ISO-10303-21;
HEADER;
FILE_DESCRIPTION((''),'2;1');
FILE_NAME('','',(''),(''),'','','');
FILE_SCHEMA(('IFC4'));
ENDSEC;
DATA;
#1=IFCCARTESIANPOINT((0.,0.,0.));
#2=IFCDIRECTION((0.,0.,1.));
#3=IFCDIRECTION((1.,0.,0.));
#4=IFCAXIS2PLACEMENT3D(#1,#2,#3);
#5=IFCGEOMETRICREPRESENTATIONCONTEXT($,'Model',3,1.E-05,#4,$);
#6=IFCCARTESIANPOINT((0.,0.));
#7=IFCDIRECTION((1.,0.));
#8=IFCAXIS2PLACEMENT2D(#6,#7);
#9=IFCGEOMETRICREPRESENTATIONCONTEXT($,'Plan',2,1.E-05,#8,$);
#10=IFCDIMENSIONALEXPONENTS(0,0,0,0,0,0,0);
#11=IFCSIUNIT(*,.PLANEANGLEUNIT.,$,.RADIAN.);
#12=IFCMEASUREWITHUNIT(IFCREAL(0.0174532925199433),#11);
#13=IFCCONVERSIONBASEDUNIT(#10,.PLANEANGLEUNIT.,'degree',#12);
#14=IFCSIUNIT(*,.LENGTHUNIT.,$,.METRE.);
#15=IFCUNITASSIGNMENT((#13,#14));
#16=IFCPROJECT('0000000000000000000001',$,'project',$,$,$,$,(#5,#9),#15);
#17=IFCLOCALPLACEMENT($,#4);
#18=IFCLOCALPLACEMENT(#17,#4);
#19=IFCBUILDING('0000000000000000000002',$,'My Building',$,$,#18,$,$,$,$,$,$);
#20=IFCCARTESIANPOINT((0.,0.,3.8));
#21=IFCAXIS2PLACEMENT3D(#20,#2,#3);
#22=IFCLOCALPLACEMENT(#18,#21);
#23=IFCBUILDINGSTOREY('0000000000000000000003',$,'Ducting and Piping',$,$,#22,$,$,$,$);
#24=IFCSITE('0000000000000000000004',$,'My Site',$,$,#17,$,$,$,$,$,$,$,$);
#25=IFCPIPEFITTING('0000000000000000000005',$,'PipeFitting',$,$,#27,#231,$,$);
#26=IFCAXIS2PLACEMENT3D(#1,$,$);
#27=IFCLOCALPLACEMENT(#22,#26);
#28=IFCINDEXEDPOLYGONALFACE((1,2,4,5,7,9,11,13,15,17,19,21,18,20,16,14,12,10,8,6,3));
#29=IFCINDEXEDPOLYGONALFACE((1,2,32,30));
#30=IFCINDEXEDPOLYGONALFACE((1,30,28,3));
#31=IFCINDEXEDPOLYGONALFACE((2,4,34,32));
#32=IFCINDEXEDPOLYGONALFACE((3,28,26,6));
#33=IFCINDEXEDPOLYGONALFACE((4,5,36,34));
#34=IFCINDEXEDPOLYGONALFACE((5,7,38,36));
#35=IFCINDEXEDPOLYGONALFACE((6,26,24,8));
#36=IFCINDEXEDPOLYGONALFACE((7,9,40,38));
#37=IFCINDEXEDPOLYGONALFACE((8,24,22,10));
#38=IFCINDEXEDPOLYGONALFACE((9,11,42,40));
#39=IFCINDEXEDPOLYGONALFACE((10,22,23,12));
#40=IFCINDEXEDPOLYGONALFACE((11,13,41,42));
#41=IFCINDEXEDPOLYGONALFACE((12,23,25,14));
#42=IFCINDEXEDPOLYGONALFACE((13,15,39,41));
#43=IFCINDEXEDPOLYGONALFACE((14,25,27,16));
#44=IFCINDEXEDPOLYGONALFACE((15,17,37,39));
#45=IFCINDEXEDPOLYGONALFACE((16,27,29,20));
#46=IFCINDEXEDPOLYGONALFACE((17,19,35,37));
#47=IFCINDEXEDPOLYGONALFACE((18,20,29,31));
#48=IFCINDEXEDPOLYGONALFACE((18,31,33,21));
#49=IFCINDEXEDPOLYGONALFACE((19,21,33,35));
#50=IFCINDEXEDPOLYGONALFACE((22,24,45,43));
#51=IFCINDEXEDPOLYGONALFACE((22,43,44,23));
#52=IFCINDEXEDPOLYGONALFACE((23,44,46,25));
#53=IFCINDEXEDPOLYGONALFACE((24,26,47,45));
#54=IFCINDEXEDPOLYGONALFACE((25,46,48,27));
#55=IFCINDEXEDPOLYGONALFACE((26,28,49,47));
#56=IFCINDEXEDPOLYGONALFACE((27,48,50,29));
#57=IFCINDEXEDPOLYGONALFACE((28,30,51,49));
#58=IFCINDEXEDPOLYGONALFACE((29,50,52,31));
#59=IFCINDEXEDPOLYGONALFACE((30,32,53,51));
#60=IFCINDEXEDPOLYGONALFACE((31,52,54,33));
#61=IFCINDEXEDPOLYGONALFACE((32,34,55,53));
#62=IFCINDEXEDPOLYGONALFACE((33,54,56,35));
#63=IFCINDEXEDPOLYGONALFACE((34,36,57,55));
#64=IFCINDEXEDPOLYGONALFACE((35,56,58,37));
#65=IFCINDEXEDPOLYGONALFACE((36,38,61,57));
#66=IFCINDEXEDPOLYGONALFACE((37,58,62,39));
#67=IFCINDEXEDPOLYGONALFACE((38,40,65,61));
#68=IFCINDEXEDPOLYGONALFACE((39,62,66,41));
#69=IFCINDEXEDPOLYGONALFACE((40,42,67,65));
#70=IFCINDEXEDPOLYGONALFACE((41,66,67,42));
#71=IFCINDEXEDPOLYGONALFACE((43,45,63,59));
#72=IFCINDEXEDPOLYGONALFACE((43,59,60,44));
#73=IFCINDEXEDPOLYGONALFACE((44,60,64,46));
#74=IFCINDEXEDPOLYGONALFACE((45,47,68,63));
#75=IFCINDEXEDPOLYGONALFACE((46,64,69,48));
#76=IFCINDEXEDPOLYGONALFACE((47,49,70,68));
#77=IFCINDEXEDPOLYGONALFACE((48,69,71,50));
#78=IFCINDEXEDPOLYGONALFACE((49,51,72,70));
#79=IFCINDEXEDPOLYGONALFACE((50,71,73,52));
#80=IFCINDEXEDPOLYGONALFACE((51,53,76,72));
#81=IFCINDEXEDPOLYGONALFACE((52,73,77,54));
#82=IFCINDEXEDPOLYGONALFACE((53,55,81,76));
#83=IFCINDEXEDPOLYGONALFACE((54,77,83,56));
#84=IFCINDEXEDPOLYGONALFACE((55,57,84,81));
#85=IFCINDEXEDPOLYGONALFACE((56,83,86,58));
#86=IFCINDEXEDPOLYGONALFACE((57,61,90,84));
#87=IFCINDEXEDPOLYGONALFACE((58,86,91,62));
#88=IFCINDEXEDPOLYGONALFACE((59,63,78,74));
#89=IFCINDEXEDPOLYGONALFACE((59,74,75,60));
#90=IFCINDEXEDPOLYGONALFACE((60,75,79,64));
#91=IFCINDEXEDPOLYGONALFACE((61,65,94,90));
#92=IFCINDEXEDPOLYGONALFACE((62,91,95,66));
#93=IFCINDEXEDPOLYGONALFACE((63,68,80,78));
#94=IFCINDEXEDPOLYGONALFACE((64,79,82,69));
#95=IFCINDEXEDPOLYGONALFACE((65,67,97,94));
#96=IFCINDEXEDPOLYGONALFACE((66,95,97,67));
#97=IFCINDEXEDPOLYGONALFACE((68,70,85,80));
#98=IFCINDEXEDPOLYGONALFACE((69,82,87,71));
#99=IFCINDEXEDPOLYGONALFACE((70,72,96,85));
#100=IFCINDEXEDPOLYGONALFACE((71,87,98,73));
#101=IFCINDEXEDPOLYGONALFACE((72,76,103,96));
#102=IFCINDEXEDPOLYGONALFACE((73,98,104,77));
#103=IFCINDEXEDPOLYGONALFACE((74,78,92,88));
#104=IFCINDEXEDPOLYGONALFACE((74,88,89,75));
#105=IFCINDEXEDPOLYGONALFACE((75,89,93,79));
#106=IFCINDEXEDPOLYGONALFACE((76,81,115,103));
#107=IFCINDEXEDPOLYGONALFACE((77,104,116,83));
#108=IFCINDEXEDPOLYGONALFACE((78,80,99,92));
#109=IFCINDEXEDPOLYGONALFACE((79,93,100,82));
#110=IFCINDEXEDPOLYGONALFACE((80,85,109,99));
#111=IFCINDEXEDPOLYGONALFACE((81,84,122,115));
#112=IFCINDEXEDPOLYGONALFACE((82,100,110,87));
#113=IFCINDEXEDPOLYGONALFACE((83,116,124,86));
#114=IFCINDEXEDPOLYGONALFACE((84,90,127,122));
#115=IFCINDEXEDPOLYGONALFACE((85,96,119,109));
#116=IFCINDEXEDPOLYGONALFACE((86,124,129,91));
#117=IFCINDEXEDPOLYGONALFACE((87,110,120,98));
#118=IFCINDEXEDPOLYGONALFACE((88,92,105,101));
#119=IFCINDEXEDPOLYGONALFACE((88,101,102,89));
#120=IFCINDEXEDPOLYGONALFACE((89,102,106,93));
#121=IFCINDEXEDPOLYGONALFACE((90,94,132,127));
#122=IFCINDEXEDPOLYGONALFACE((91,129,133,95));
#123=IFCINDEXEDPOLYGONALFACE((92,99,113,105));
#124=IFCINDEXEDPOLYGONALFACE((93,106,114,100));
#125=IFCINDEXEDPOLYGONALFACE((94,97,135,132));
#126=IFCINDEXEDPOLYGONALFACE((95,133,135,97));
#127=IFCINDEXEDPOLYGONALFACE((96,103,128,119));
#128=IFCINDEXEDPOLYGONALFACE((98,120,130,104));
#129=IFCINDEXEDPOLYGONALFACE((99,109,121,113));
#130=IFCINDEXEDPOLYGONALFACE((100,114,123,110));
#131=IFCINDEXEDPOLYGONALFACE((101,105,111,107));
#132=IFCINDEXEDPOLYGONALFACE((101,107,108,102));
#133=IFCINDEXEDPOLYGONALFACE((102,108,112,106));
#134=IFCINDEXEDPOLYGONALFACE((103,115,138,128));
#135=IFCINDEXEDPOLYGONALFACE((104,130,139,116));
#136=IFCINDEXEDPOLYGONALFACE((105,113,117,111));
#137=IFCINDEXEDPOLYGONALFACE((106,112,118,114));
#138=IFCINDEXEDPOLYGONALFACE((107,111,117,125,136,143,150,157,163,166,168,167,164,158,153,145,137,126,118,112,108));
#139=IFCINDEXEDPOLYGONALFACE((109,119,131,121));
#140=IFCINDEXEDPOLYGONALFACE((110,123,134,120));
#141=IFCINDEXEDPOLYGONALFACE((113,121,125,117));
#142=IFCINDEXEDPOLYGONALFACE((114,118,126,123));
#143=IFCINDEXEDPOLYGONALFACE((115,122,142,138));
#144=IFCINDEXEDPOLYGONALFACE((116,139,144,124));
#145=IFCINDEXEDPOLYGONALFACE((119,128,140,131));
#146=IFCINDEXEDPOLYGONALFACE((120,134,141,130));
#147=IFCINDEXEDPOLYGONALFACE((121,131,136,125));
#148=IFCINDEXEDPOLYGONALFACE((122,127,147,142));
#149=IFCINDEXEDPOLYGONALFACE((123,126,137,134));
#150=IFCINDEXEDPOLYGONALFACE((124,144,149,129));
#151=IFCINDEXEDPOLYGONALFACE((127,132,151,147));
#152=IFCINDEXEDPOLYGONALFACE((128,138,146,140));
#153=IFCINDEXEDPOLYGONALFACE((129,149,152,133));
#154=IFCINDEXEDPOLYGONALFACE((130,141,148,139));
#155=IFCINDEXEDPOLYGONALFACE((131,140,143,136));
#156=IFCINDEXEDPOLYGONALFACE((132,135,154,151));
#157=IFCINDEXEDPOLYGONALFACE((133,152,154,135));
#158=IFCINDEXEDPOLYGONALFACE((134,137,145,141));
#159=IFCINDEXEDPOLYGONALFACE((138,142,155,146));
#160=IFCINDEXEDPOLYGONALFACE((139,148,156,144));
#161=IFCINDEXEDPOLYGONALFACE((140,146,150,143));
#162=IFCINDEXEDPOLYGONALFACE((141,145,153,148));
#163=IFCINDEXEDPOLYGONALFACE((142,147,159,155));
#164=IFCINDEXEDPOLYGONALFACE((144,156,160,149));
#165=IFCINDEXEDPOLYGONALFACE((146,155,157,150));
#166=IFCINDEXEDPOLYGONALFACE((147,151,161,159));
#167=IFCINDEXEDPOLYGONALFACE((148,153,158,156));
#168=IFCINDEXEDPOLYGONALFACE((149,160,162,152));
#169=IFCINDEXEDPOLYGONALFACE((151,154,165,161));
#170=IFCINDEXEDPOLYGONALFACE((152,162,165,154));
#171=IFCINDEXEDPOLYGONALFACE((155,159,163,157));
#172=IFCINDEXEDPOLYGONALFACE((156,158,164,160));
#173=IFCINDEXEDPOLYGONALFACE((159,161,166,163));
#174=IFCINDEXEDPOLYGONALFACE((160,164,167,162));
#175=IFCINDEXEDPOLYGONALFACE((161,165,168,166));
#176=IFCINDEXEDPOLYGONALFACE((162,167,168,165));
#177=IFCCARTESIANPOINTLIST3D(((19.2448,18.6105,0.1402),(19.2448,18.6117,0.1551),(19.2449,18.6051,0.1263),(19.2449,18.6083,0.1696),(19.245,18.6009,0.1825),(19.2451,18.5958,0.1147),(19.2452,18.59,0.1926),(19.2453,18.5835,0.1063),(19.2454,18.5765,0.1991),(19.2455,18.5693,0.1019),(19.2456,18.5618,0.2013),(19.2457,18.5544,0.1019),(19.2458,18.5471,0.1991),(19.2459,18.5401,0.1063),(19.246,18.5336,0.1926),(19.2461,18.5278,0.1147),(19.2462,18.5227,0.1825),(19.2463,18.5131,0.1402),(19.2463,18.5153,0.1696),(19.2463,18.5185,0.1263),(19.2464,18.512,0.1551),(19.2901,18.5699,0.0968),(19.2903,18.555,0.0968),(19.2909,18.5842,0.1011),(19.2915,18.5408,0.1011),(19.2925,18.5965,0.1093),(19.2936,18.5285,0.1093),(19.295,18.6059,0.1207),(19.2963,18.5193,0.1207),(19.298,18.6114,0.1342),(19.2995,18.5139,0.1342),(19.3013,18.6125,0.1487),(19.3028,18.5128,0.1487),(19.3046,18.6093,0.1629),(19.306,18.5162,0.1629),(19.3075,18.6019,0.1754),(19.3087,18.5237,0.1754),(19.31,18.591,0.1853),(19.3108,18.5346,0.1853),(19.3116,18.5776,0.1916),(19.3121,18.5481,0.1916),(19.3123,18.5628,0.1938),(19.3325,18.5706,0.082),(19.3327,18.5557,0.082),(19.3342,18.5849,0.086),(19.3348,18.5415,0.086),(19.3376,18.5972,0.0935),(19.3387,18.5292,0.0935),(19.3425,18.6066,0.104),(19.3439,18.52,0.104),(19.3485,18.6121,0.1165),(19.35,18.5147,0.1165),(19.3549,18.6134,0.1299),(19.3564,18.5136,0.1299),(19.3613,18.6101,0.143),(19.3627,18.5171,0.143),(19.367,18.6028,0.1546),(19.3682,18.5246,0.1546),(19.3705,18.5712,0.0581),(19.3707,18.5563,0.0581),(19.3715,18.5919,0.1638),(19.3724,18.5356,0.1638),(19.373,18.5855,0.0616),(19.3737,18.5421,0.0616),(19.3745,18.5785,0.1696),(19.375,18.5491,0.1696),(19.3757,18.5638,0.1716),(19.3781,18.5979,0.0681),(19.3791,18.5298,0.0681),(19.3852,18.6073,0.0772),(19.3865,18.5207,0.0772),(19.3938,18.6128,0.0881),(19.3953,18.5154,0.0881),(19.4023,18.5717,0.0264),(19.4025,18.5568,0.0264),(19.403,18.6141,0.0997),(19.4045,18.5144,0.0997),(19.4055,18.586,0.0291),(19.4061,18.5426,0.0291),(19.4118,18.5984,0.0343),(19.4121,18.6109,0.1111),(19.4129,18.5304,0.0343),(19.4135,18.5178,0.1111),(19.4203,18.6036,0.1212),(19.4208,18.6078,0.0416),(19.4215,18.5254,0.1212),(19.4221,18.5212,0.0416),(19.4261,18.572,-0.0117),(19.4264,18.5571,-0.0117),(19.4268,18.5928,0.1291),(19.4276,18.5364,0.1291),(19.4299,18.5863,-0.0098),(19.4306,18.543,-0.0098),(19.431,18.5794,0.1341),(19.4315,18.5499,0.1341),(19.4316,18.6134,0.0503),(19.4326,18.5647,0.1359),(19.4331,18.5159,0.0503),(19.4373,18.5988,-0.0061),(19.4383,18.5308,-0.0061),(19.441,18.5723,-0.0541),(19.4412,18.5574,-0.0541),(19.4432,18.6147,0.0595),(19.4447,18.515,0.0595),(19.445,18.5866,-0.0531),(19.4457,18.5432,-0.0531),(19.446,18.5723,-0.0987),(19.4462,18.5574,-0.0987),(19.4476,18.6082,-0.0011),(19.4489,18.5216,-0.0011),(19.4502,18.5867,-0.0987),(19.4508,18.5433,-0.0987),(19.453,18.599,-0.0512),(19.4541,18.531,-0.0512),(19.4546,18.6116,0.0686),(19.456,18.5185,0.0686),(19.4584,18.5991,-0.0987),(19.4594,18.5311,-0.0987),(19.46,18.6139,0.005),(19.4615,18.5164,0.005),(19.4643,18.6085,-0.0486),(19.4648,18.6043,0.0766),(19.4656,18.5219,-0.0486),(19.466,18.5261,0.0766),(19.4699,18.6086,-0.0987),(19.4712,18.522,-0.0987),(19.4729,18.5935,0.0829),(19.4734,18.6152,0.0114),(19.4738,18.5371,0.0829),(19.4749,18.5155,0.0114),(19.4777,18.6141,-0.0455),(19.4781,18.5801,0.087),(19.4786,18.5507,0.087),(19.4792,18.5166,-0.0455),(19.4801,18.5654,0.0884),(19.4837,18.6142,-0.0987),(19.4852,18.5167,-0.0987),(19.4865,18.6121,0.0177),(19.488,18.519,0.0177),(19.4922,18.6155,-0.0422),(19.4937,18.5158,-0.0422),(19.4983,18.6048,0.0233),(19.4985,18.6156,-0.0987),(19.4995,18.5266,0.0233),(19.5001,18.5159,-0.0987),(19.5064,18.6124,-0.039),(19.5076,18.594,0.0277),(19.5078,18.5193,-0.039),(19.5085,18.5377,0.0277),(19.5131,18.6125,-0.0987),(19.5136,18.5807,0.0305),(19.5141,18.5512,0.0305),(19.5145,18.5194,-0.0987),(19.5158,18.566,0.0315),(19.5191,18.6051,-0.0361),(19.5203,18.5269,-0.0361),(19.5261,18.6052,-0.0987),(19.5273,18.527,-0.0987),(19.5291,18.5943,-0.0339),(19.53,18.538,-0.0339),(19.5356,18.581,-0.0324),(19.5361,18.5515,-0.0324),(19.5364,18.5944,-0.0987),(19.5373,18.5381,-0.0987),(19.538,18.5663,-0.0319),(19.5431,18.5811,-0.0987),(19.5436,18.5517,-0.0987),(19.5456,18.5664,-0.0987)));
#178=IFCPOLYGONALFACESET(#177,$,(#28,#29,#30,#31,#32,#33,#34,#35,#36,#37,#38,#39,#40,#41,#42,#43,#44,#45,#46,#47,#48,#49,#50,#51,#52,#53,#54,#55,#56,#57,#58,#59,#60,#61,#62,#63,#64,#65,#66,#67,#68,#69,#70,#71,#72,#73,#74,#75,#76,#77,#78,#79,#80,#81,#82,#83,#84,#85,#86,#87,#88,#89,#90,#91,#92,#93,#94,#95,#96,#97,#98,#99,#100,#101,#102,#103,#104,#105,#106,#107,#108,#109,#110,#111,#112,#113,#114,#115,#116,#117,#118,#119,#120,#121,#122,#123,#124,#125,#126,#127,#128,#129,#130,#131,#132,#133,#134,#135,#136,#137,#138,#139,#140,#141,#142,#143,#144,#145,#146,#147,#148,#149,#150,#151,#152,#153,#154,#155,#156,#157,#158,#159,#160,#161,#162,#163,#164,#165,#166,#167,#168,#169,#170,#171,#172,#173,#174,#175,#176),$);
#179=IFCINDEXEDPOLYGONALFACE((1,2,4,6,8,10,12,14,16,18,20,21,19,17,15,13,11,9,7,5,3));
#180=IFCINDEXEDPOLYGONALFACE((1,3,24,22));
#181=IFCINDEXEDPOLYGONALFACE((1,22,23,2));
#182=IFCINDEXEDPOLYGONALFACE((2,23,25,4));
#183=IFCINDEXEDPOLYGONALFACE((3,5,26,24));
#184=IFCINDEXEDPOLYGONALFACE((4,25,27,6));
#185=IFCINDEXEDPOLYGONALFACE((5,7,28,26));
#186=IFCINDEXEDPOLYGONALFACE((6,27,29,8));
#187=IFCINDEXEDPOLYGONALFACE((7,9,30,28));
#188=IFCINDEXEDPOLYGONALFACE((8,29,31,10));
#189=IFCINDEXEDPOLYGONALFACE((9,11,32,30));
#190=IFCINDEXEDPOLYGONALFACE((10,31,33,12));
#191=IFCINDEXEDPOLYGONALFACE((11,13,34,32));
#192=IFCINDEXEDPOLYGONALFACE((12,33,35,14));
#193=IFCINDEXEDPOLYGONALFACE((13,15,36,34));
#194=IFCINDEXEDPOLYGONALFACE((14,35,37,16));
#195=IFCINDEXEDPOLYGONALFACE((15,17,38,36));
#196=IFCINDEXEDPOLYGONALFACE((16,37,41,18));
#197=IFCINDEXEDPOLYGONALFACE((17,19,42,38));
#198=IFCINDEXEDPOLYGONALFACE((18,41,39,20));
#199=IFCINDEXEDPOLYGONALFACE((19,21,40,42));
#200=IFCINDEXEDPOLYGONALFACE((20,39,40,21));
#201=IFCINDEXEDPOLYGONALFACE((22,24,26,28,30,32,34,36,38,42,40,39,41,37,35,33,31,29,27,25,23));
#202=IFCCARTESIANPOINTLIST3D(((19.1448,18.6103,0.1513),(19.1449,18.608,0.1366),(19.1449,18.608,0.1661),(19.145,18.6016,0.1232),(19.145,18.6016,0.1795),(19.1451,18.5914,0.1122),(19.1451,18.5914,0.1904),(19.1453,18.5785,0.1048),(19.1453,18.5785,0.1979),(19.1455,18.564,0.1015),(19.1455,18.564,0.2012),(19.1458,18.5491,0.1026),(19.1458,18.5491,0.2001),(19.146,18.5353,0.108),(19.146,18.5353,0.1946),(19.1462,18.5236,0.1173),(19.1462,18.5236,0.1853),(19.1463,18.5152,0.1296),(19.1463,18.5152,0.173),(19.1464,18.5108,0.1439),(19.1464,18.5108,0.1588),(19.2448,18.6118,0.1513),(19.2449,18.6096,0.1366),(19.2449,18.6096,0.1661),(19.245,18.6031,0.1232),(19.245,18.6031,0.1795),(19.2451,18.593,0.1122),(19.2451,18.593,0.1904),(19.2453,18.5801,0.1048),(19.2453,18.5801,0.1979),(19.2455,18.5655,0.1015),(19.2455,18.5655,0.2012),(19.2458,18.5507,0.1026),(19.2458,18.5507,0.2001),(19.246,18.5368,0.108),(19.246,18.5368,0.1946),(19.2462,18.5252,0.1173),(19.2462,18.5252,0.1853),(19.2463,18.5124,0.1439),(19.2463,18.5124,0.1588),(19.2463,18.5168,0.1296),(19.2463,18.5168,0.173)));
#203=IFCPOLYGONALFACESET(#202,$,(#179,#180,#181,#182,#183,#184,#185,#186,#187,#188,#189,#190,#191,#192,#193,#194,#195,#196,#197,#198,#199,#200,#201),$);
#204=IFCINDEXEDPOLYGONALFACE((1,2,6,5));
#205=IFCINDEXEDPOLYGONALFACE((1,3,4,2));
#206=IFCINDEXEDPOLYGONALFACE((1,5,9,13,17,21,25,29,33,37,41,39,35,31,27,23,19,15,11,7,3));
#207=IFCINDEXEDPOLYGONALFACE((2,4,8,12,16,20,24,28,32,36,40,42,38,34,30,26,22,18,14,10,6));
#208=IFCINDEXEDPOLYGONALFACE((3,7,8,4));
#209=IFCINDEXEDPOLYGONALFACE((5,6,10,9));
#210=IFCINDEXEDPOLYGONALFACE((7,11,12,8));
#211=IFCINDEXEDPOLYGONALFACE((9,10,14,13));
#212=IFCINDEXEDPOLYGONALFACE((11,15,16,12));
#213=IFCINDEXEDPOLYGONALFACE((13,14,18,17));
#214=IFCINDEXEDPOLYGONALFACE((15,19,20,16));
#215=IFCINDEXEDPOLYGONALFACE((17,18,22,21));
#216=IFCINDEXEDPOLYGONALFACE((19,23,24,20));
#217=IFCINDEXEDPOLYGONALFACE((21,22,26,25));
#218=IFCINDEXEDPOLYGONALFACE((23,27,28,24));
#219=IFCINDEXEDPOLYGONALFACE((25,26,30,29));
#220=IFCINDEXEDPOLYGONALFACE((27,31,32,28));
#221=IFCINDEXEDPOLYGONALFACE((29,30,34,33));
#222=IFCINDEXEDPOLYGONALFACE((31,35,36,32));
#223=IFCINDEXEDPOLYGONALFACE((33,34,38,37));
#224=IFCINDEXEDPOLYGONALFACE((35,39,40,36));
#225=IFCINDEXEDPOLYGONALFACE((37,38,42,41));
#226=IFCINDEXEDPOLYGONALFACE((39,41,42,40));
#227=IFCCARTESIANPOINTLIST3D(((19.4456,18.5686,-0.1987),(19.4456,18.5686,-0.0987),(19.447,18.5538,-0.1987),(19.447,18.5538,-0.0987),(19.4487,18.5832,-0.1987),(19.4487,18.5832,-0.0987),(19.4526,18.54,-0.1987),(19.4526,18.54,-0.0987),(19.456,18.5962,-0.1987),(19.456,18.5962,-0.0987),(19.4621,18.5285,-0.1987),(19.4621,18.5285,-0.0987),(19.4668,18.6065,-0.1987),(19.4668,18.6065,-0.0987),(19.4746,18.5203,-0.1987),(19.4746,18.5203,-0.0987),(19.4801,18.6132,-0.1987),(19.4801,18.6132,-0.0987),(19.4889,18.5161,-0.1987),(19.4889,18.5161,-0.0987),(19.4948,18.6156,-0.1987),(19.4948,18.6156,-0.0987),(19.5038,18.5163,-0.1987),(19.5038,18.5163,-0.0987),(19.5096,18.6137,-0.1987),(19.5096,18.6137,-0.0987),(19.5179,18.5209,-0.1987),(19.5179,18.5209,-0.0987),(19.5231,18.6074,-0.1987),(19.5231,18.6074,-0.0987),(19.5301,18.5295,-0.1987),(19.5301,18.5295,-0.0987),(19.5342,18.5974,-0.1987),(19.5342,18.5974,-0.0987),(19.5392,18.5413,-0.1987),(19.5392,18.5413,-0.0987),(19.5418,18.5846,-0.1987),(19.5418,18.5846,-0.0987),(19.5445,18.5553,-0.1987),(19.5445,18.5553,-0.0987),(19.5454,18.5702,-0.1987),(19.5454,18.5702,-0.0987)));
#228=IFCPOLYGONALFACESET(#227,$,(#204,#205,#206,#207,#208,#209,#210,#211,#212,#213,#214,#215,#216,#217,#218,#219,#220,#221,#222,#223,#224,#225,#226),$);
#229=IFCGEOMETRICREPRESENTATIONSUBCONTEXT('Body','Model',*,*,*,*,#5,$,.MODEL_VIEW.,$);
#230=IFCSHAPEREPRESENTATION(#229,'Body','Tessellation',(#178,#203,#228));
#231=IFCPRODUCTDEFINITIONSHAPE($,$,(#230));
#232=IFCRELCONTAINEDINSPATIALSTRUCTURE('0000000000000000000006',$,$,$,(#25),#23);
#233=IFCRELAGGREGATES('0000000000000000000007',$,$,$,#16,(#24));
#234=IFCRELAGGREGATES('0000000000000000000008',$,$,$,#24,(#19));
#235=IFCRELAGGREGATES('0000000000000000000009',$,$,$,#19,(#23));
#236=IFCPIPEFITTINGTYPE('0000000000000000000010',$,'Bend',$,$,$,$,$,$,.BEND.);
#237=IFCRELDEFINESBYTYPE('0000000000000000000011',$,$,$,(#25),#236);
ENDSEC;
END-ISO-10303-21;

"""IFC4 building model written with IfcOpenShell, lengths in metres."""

from ifc_helpers import new_model, entity, si_unit, converted_unit, frame, origin_with_axes, origin_2d_with_axis, place, context, subcontext, project, spatial, circle, extrude, source, transform, mapped, type_object, type_shapes, element, save


model = new_model("IFC4")

# Units and contexts
model_context = context("Model", 3, precision=1e-05, world=origin_with_axes())
plan_context = context("Plan", 2, precision=1e-05, world=origin_2d_with_axis())
body_context = subcontext(model_context, "Body", "Model", "MODEL_VIEW")
ifc_project = project(units=[converted_unit("PLANEANGLEUNIT", "degree", entity("IfcReal", 0.0174532925199433), si_unit("PLANEANGLEUNIT", "RADIAN"), dimensions=[0, 0, 0, 0, 0, 0, 0]), si_unit("LENGTHUNIT", "METRE")], contexts=[model_context, plan_context])

# Site, building, storey
site_placement = place(None, origin_with_axes())
site = spatial("IfcSite", under=ifc_project, at=site_placement, Name="My Site")
building_placement = place(site_placement, origin_with_axes())
building = spatial("IfcBuilding", under=site, at=building_placement, Name="My Building")
storey_placement = place(building_placement, frame((0.0, 0.0, 3.8), z_axis=(0.0, 0.0, 1.0), x_axis=(1.0, 0.0, 0.0)))
storey = spatial("IfcBuildingStorey", under=building, at=storey_placement, Name="Ducting and Piping")

# Pipe fitting
pipe_fitting_type = type_object("IfcPipeFittingType", Name="Bend", PredefinedType="BEND")
shared_shape = source(origin_with_axes(), body_context, "Body", "SolidModel", [
    entity("IfcSweptDiskSolid", entity("IfcIndexedPolyCurve", entity("IfcCartesianPointList3D", [[0.0, 0.0, 0.1], [0.0, -0.0732, 0.2768], [0.0, -0.25, 0.35]]), [entity("IfcArcIndex", [1, 2, 3])]), 0.05),
    extrude(circle(Radius=0.05), origin_with_axes(), (0.0, 0.0, 1.0), 0.1),
    extrude(circle(Radius=0.05), frame((0.0, -0.25, 0.35), z_axis=(0.0, -1.0, 0.0), x_axis=(1.0, 0.0, 0.0)), (0.0, 0.0, 1.0), 0.1),
])
type_shapes(pipe_fitting_type, [shared_shape])
for number, where, z_axis, x_axis, name in (
    (1, (19.1456, 18.5603, 0.1513), (0.999882, 0.015371, 0.0), (-0.015371, 0.999882, 0.0), "PipeFitting"),
):
    element("IfcPipeFitting", number, at=place(storey_placement, frame(where, z_axis=z_axis, x_axis=x_axis)), inside=storey, type_object=pipe_fitting_type, Name=name, context=body_context, shape_type="MappedRepresentation", body=[
        mapped(shared_shape, transform((0.0, 0.0, 0.0), x_axis=(1.0, 0.0, 0.0), y_axis=(0.0, 1.0, 0.0), z_axis=(0.0, 0.0, 1.0), scale=1.0)),
    ])

save(model, "model.ifc")
